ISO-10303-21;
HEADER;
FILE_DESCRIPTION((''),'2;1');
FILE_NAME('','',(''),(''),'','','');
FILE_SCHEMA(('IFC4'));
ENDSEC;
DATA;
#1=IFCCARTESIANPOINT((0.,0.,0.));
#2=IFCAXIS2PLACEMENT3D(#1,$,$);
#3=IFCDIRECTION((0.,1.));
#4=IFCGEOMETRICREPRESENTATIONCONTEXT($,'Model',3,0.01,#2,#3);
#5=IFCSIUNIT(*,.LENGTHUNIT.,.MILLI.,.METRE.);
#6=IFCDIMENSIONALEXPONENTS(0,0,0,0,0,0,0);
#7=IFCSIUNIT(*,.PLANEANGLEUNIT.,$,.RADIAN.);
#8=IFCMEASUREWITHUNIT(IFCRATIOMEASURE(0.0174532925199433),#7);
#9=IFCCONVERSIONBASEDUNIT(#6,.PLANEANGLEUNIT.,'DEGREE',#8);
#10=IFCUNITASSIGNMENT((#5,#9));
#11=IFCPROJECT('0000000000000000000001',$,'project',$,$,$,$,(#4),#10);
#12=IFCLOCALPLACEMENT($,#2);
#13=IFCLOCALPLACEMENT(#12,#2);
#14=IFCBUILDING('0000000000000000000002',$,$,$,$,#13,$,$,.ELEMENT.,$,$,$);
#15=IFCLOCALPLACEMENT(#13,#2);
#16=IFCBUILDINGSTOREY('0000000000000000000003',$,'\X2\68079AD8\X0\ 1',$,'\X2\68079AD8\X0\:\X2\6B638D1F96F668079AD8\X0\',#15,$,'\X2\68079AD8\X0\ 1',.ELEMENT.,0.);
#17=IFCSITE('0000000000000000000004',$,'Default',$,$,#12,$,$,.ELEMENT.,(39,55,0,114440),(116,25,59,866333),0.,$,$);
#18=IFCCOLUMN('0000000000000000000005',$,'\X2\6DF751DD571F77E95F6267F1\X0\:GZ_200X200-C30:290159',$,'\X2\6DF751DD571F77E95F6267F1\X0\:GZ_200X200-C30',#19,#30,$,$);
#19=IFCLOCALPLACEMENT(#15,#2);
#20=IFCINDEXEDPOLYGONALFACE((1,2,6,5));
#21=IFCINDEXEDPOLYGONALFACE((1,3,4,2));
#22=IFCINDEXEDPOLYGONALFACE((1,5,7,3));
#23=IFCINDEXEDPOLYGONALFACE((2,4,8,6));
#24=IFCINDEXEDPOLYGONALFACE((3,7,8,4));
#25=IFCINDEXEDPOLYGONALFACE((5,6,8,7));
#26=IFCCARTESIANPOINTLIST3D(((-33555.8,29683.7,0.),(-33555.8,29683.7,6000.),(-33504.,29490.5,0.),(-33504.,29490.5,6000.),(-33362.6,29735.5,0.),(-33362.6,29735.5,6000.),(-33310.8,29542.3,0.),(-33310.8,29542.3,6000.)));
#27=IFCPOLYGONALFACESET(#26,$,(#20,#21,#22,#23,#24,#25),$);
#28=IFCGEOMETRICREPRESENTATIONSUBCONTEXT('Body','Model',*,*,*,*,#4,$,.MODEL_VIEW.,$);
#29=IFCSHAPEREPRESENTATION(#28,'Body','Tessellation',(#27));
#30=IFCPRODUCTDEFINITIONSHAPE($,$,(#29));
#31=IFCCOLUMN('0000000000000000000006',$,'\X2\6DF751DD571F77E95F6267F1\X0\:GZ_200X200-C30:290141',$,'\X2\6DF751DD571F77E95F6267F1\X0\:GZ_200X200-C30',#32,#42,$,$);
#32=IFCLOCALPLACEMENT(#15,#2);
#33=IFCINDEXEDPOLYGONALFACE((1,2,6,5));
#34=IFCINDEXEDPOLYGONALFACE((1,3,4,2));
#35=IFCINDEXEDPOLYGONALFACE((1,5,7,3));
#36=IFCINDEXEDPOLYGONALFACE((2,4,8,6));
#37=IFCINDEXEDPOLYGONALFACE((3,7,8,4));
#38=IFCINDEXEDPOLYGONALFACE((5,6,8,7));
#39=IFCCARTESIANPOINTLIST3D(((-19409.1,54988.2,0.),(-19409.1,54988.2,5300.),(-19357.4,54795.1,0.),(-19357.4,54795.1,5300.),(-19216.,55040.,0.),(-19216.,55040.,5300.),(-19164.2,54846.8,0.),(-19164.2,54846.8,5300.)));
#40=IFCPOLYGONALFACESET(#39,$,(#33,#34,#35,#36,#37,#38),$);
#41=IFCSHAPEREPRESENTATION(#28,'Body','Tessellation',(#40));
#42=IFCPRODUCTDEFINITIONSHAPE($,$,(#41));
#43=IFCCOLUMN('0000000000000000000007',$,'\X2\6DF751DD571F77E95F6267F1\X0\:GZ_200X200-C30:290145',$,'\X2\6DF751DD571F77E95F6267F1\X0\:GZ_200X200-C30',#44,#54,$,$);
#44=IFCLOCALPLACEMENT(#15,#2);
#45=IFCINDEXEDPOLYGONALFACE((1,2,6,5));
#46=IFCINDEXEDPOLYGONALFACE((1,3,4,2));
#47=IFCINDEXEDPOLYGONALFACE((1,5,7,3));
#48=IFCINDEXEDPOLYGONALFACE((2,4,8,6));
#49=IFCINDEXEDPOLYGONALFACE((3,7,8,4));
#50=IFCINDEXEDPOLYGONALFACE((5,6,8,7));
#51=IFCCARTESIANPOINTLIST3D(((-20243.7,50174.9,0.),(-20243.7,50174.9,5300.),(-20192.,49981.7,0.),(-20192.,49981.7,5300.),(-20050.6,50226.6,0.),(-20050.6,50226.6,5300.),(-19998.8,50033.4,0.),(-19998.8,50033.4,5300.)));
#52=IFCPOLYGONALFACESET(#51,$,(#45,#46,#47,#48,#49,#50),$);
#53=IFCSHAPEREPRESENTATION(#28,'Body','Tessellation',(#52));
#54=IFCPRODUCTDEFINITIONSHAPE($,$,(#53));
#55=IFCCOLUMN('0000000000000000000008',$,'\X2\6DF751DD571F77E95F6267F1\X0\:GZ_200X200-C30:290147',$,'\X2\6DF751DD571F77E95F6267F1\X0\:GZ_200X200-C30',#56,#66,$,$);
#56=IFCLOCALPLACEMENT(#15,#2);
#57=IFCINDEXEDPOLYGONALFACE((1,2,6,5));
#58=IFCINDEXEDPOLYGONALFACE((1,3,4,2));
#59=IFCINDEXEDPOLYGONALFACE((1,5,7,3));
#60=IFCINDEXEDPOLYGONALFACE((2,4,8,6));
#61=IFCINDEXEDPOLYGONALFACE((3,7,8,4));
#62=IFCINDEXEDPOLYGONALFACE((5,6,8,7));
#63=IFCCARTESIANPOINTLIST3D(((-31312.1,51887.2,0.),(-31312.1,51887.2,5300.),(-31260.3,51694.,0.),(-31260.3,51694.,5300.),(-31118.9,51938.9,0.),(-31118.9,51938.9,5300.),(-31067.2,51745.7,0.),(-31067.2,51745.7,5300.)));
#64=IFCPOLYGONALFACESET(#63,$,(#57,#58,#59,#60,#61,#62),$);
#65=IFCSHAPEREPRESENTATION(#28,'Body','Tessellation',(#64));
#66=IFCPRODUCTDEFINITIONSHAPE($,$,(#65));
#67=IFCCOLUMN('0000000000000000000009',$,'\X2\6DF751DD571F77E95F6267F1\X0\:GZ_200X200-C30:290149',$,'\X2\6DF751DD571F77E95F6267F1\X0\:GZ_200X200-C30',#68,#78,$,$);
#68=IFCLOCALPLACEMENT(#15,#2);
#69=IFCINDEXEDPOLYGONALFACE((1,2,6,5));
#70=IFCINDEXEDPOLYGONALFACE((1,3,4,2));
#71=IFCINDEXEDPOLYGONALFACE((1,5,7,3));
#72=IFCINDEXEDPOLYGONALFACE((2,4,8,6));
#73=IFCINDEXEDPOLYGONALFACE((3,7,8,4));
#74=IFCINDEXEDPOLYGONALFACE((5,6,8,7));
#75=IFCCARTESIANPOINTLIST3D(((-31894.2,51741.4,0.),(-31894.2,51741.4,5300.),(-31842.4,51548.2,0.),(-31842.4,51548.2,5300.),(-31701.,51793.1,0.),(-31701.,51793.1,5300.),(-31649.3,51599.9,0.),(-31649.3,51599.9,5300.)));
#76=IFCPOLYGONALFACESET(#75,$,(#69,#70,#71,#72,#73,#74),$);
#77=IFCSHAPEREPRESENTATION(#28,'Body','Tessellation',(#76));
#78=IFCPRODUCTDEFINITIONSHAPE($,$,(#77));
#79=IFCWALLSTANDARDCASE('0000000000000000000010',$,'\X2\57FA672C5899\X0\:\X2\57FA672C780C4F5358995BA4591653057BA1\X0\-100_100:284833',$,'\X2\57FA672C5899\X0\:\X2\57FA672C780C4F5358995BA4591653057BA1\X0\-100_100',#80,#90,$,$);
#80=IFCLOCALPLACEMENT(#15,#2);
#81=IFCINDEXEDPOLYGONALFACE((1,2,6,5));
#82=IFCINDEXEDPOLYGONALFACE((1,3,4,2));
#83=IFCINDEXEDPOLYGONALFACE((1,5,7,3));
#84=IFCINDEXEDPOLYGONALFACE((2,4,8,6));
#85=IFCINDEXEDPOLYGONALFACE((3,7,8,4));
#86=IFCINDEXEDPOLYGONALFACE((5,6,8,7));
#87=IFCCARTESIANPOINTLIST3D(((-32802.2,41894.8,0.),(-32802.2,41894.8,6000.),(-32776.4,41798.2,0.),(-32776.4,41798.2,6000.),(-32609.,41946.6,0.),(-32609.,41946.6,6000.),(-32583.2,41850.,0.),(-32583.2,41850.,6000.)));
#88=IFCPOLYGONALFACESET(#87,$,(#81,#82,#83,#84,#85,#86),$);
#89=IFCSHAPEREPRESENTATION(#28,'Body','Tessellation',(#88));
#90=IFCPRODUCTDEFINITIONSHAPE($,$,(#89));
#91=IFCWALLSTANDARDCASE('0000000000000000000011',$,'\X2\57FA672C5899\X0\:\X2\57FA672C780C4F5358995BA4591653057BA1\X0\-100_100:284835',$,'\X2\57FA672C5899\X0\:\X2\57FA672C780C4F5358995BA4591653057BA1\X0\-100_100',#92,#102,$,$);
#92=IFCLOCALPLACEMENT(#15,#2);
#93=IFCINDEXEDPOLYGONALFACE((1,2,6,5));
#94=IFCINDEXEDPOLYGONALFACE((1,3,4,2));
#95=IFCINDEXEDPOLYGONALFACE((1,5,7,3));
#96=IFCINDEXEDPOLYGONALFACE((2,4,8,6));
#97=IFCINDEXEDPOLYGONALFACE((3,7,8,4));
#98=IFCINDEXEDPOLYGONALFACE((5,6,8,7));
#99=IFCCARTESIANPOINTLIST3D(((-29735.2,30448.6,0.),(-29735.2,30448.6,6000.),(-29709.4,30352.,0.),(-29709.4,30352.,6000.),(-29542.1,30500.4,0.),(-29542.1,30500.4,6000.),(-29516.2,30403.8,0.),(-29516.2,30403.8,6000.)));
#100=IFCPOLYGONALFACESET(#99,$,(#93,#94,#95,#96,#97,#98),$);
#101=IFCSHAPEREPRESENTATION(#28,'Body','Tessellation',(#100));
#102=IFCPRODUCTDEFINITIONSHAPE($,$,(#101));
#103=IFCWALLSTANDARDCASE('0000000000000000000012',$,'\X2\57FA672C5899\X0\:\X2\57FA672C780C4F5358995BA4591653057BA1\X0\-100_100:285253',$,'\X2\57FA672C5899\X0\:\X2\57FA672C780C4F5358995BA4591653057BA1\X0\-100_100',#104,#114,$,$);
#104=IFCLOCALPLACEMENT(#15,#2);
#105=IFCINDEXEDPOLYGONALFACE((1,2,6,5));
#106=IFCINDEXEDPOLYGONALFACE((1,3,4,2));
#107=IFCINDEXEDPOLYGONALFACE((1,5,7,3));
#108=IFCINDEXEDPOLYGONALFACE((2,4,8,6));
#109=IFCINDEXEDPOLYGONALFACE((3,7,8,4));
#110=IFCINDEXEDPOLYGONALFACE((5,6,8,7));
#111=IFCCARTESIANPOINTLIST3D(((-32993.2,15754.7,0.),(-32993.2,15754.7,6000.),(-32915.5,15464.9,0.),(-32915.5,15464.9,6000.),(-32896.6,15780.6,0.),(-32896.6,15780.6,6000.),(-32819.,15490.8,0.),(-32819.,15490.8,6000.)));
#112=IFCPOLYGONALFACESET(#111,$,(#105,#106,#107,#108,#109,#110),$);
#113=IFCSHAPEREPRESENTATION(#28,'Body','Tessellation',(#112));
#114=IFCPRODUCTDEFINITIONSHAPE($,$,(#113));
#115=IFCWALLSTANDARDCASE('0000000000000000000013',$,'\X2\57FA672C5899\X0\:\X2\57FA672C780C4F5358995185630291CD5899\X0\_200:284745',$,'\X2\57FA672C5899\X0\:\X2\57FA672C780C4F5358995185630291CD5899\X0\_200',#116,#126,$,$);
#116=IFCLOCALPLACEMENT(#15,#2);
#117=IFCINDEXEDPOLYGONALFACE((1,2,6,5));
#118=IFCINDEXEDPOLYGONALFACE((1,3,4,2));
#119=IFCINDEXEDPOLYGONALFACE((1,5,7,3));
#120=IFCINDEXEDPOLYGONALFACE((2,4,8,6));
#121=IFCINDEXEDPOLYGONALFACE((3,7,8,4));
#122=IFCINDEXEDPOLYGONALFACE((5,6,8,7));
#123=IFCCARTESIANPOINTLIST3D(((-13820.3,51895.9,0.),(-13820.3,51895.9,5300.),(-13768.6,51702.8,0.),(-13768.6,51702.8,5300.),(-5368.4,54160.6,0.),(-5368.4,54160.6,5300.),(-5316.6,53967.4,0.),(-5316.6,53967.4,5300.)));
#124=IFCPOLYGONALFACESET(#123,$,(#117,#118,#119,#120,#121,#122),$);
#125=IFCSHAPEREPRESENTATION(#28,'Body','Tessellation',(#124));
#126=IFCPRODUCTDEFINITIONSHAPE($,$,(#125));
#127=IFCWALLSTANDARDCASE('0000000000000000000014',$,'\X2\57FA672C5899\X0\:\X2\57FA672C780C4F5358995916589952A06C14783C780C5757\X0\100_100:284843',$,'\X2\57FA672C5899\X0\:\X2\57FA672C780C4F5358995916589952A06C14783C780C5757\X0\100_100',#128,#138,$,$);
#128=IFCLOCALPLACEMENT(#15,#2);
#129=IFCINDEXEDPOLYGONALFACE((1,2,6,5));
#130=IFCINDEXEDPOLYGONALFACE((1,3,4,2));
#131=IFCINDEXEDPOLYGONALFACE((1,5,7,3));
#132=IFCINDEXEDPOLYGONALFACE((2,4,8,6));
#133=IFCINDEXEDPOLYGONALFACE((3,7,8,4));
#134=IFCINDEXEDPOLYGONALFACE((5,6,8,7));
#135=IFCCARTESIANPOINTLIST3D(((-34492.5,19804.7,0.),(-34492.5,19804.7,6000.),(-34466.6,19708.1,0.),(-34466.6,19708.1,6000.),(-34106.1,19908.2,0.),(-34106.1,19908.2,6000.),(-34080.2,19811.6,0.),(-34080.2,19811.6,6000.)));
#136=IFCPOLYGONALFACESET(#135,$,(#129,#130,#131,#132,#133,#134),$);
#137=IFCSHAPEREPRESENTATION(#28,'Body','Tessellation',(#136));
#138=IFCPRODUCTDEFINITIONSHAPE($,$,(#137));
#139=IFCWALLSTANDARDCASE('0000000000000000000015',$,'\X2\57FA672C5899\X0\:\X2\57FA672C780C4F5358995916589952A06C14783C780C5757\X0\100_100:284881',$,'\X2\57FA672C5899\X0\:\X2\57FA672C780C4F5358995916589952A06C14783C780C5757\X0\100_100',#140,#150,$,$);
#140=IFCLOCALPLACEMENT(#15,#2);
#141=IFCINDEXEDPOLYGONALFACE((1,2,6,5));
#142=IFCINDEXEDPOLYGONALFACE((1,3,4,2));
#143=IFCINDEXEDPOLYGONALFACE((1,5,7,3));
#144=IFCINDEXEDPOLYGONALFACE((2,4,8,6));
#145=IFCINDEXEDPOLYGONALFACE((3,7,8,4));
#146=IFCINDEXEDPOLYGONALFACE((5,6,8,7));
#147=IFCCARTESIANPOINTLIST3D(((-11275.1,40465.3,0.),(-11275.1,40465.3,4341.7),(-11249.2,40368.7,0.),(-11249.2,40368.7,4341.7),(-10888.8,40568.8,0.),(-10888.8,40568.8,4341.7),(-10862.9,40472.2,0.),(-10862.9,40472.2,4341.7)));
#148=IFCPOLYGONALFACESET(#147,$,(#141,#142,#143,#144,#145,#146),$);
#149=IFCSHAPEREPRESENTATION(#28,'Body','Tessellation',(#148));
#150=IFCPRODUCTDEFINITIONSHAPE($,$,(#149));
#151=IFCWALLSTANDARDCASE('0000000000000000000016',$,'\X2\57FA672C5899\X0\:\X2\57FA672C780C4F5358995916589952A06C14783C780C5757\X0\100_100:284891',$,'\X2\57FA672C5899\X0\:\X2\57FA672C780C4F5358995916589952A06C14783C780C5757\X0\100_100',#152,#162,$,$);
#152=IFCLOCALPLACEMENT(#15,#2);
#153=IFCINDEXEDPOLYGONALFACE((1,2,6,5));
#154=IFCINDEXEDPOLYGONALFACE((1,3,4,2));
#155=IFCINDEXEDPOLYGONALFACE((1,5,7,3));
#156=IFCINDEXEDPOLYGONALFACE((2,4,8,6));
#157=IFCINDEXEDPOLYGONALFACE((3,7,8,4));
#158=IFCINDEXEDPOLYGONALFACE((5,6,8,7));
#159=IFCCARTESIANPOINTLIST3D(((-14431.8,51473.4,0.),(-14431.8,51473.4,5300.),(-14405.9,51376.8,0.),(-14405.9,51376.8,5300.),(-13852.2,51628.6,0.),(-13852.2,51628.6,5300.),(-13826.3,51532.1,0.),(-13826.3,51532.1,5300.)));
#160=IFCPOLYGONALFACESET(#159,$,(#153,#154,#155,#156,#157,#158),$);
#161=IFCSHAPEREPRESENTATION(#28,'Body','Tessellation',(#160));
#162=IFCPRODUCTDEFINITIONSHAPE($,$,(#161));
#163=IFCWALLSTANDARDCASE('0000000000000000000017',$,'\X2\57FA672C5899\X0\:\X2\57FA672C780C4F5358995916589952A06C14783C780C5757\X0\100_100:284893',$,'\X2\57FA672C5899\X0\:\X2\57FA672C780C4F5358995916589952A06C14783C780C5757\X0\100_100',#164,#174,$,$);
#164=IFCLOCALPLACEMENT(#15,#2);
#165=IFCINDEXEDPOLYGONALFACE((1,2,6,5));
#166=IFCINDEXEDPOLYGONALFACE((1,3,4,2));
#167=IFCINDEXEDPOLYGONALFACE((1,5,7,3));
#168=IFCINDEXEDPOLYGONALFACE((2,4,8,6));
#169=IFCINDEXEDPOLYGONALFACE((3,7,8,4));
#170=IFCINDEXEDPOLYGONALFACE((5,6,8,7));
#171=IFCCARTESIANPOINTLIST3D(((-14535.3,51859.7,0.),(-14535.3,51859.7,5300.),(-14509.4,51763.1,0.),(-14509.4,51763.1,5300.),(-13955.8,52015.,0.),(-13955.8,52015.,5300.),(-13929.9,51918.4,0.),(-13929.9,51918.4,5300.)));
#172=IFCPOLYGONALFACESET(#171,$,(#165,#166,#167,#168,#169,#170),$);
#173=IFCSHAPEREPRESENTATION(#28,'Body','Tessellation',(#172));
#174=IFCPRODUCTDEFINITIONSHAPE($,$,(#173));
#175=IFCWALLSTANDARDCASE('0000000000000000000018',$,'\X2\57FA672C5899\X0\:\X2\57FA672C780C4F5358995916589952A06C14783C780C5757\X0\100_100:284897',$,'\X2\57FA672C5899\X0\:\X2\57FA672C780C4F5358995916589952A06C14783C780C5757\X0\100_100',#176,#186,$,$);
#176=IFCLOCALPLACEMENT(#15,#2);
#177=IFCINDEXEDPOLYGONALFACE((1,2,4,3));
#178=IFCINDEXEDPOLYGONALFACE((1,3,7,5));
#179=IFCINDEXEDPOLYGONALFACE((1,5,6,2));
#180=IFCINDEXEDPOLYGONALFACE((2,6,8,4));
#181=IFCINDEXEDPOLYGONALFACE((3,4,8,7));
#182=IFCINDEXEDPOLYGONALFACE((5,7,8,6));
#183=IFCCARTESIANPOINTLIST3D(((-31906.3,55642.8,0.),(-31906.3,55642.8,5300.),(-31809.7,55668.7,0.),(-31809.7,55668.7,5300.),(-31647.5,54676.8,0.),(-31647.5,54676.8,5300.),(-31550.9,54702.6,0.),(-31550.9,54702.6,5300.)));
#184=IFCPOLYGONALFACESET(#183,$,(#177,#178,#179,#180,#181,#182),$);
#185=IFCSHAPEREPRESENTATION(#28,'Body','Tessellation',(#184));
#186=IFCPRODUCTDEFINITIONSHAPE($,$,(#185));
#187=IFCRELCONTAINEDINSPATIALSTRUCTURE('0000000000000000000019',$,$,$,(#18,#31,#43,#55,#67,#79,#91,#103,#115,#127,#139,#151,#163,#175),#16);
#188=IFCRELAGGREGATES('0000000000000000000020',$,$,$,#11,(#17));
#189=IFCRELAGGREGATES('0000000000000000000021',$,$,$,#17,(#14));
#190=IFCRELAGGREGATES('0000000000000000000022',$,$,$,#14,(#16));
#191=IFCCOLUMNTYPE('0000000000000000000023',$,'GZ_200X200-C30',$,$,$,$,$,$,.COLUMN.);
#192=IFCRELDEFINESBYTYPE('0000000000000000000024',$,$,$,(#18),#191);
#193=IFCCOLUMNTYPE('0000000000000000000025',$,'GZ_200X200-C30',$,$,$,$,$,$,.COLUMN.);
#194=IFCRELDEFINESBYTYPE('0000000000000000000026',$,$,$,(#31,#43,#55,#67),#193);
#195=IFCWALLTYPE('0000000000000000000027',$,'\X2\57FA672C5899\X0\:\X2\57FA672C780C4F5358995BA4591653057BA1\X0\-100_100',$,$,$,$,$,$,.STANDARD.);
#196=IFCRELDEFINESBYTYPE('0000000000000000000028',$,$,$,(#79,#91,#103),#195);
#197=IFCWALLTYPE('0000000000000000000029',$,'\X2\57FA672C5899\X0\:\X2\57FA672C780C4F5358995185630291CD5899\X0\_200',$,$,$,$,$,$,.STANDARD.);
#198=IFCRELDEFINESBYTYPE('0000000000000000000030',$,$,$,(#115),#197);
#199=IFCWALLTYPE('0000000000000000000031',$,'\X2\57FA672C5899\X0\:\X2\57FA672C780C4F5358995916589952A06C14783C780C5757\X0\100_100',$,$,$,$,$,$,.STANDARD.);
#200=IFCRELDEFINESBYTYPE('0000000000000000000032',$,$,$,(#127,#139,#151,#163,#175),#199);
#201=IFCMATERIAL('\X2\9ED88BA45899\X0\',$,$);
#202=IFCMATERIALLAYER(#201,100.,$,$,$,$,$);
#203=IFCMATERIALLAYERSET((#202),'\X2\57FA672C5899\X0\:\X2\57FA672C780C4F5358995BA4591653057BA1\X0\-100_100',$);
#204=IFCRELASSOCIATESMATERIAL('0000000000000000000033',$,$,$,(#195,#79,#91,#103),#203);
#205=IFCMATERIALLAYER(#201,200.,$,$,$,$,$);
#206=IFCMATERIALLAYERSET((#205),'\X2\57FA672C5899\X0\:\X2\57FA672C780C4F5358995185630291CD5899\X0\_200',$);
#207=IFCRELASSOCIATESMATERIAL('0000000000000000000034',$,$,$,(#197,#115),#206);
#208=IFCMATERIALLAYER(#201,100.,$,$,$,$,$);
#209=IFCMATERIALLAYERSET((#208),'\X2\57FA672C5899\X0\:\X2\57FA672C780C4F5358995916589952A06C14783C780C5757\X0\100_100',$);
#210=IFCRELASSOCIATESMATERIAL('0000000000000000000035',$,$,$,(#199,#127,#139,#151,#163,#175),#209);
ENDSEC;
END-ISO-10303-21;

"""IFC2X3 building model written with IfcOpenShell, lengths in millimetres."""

from ifc_helpers import new_model, entity, si_unit, converted_unit, direction, frame, frame_2d, origin, origin_2d_with_axis, place, context, subcontext, project, spatial, rectangle, extrude, source, transform, mapped, material, layer, layer_set, layer_usage, type_object, type_shapes, element, save


model = new_model("IFC2X3")

# Units and contexts
model_context = context("Model", 3, precision=0.01, world=origin(), true_north=direction((0.0, 1.0)))
body_context = subcontext(model_context, "Body", "Model", "MODEL_VIEW")
ifc_project = project(units=[si_unit("LENGTHUNIT", "METRE", prefix="MILLI"), converted_unit("PLANEANGLEUNIT", "DEGREE", entity("IfcRatioMeasure", 0.0174532925199433), si_unit("PLANEANGLEUNIT", "RADIAN"), dimensions=[0, 0, 0, 0, 0, 0, 0])], contexts=[model_context])

# Site, building, storey
site_placement = place(None, origin())
site = spatial("IfcSite", under=ifc_project, at=site_placement, Name="Default", CompositionType="ELEMENT", RefLatitude=(39, 55, 0, 114440), RefLongitude=(116, 25, 59, 866333), RefElevation=0.0)
building_placement = place(site_placement, origin())
building = spatial("IfcBuilding", under=site, at=building_placement, CompositionType="ELEMENT")
storey_placement = place(building_placement, origin())
storey = spatial("IfcBuildingStorey", under=building, at=storey_placement, Name="标高 1", ObjectType="标高:正负零标高", LongName="标高 1", CompositionType="ELEMENT", Elevation=0.0)

# Columns
column_type_1 = type_object("IfcColumnType", Name="GZ_200X200-C30", PredefinedType="COLUMN")
shared_shape_1 = source(origin(), body_context, "Body", "SweptSolid", [
    extrude(rectangle(XDim=200.0, YDim=200.0, at=origin_2d_with_axis()), frame((0.0, 0.0, 0.0), z_axis=(0.0, 0.0, 1.0), x_axis=(0.0, -1.0, 0.0)), (0.0, 0.0, 1.0), 6000.0),
])
type_shapes(column_type_1, [shared_shape_1])
for number, where, z_axis, x_axis, name in (
    (1, (-33433.3, 29613.0, 0.0), (0.0, 0.0, 1.0), (0.965926, 0.258819, 0.0), "混凝土矩形柱:GZ_200X200-C30:290159"),
):
    element("IfcColumn", number, at=place(building_placement, frame(where, z_axis=z_axis, x_axis=x_axis)), inside=storey, type_object=column_type_1, Name=name, ObjectType="混凝土矩形柱:GZ_200X200-C30", context=body_context, shape_type="MappedRepresentation", body=[
        mapped(shared_shape_1, transform((0.0, 0.0, 0.0), scale=1.0)),
    ])
column_type_2 = type_object("IfcColumnType", Name="GZ_200X200-C30", PredefinedType="COLUMN")
shared_shape_2 = source(origin(), body_context, "Body", "SweptSolid", [
    extrude(rectangle(XDim=200.0, YDim=200.0, at=origin_2d_with_axis()), frame((0.0, 0.0, 0.0), z_axis=(0.0, 0.0, 1.0), x_axis=(0.0, -1.0, 0.0)), (0.0, 0.0, 1.0), 5300.0),
])
type_shapes(column_type_2, [shared_shape_2])
for number, where, z_axis, x_axis, name in (
    (2, (-19286.7, 54917.5, 0.0), (0.0, 0.0, 1.0), (0.965926, 0.258819, 0.0), "混凝土矩形柱:GZ_200X200-C30:290141"),
    (3, (-20121.3, 50104.2, 0.0), (0.0, 0.0, 1.0), (0.965926, 0.258819, 0.0), "混凝土矩形柱:GZ_200X200-C30:290145"),
    (4, (-31189.6, 51816.4, 0.0), (0.0, 0.0, 1.0), (0.965926, 0.258819, 0.0), "混凝土矩形柱:GZ_200X200-C30:290147"),
    (5, (-31771.7, 51670.6, 0.0), (0.0, 0.0, 1.0), (0.965926, 0.258819, 0.0), "混凝土矩形柱:GZ_200X200-C30:290149"),
):
    element("IfcColumn", number, at=place(building_placement, frame(where, z_axis=z_axis, x_axis=x_axis)), inside=storey, type_object=column_type_2, Name=name, ObjectType="混凝土矩形柱:GZ_200X200-C30", context=body_context, shape_type="MappedRepresentation", body=[
        mapped(shared_shape_2, transform((0.0, 0.0, 0.0), scale=1.0)),
    ])

# Walls
ifc_material = material(Name="默认墙")
ifc_layer_1 = layer(ifc_material, 100.0)
ifc_layer_set_1 = layer_set([ifc_layer_1], Name="基本墙:基本砌体墙室外包管-100_100")
ifc_layer_usage_1 = layer_usage(ifc_layer_set_1, "AXIS2", "NEGATIVE", 50.0)
wall_type_1 = type_object("IfcWallType", Name="基本墙:基本砌体墙室外包管-100_100", PredefinedType="STANDARD", material=ifc_layer_set_1)
wall_1_placement = place(building_placement, frame((-32596.1, 41898.3, 0.0), z_axis=(0.0, 0.0, 1.0), x_axis=(-0.965926, -0.258819, 0.0)))
element("IfcWallStandardCase", 6, at=wall_1_placement, inside=storey, type_object=wall_type_1, material=ifc_layer_usage_1, Name="基本墙:基本砌体墙室外包管-100_100:284833", ObjectType="基本墙:基本砌体墙室外包管-100_100", context=body_context, shape_type="SweptSolid", body=[
    extrude(rectangle(XDim=200.0, YDim=100.0, at=frame_2d((100.0, 0.0), x_axis=(-1.0, 0.0))), origin(), (0.0, 0.0, 1.0), 6000.0),
])
ifc_layer_usage_2 = layer_usage(ifc_layer_set_1, "AXIS2", "NEGATIVE", 50.0)
wall_2_placement = place(building_placement, frame((-29529.1, 30452.1, 0.0), z_axis=(0.0, 0.0, 1.0), x_axis=(-0.965926, -0.258819, 0.0)))
element("IfcWallStandardCase", 7, at=wall_2_placement, inside=storey, type_object=wall_type_1, material=ifc_layer_usage_2, Name="基本墙:基本砌体墙室外包管-100_100:284835", ObjectType="基本墙:基本砌体墙室外包管-100_100", context=body_context, shape_type="SweptSolid", body=[
    extrude(rectangle(XDim=200.0, YDim=100.0, at=frame_2d((100.0, 0.0), x_axis=(-1.0, 0.0))), origin(), (0.0, 0.0, 1.0), 6000.0),
])
ifc_layer_usage_3 = layer_usage(ifc_layer_set_1, "AXIS2", "NEGATIVE", 50.0)
wall_3_placement = place(building_placement, frame((-32944.9, 15767.6, 0.0), z_axis=(0.0, 0.0, 1.0), x_axis=(0.258819, -0.965926, 0.0)))
element("IfcWallStandardCase", 8, at=wall_3_placement, inside=storey, type_object=wall_type_1, material=ifc_layer_usage_3, Name="基本墙:基本砌体墙室外包管-100_100:285253", ObjectType="基本墙:基本砌体墙室外包管-100_100", context=body_context, shape_type="SweptSolid", body=[
    extrude(rectangle(XDim=300.0, YDim=100.0, at=frame_2d((150.0, 0.0), x_axis=(-1.0, 0.0))), origin(), (0.0, 0.0, 1.0), 6000.0),
])
ifc_layer_2 = layer(ifc_material, 200.0)
ifc_layer_set_2 = layer_set([ifc_layer_2], Name="基本墙:基本砌体墙内挂重墙_200")
ifc_layer_usage_4 = layer_usage(ifc_layer_set_2, "AXIS2", "NEGATIVE", 100.0)
wall_type_2 = type_object("IfcWallType", Name="基本墙:基本砌体墙内挂重墙_200", PredefinedType="STANDARD", material=ifc_layer_set_2)
wall_4_placement = place(building_placement, frame((-13794.4, 51799.3, 0.0), z_axis=(0.0, 0.0, 1.0), x_axis=(0.965926, 0.258819, 0.0)))
element("IfcWallStandardCase", 9, at=wall_4_placement, inside=storey, type_object=wall_type_2, material=ifc_layer_usage_4, Name="基本墙:基本砌体墙内挂重墙_200:284745", ObjectType="基本墙:基本砌体墙内挂重墙_200", context=body_context, shape_type="SweptSolid", body=[
    extrude(rectangle(XDim=8750.1, YDim=200.0, at=frame_2d((4375.0, 0.0), x_axis=(-1.0, 0.0))), origin(), (0.0, 0.0, 1.0), 5300.0),
])
ifc_layer_3 = layer(ifc_material, 100.0)
ifc_layer_set_3 = layer_set([ifc_layer_3], Name="基本墙:基本砌体墙外墙加气砼砌块100_100")
ifc_layer_usage_5 = layer_usage(ifc_layer_set_3, "AXIS2", "NEGATIVE", 50.0)
wall_type_3 = type_object("IfcWallType", Name="基本墙:基本砌体墙外墙加气砼砌块100_100", PredefinedType="STANDARD", material=ifc_layer_set_3)
wall_5_placement = place(building_placement, frame((-34479.5, 19756.4, 0.0), z_axis=(0.0, 0.0, 1.0), x_axis=(0.965926, 0.258819, 0.0)))
element("IfcWallStandardCase", 10, at=wall_5_placement, inside=storey, type_object=wall_type_3, material=ifc_layer_usage_5, Name="基本墙:基本砌体墙外墙加气砼砌块100_100:284843", ObjectType="基本墙:基本砌体墙外墙加气砼砌块100_100", context=body_context, shape_type="SweptSolid", body=[
    extrude(rectangle(XDim=400.0, YDim=100.0, at=frame_2d((200.0, 0.0), x_axis=(-1.0, 0.0))), origin(), (0.0, 0.0, 1.0), 6000.0),
])
ifc_layer_usage_6 = layer_usage(ifc_layer_set_3, "AXIS2", "NEGATIVE", 50.0)
wall_6_placement = place(building_placement, frame((-11262.2, 40417.0, 0.0), z_axis=(0.0, 0.0, 1.0), x_axis=(0.965926, 0.258819, 0.0)))
element("IfcWallStandardCase", 11, at=wall_6_placement, inside=storey, type_object=wall_type_3, material=ifc_layer_usage_6, Name="基本墙:基本砌体墙外墙加气砼砌块100_100:284881", ObjectType="基本墙:基本砌体墙外墙加气砼砌块100_100", context=body_context, shape_type="SweptSolid", body=[
    extrude(rectangle(XDim=400.0, YDim=100.0, at=frame_2d((200.0, 0.0), x_axis=(-1.0, 0.0))), origin(), (0.0, 0.0, 1.0), 4341.7),
])
ifc_layer_usage_7 = layer_usage(ifc_layer_set_3, "AXIS2", "NEGATIVE", 50.0)
wall_7_placement = place(building_placement, frame((-14418.8, 51425.1, 0.0), z_axis=(0.0, 0.0, 1.0), x_axis=(0.965926, 0.258819, 0.0)))
element("IfcWallStandardCase", 12, at=wall_7_placement, inside=storey, type_object=wall_type_3, material=ifc_layer_usage_7, Name="基本墙:基本砌体墙外墙加气砼砌块100_100:284891", ObjectType="基本墙:基本砌体墙外墙加气砼砌块100_100", context=body_context, shape_type="SweptSolid", body=[
    extrude(rectangle(XDim=600.0, YDim=100.0, at=frame_2d((300.0, 0.0), x_axis=(-1.0, 0.0))), origin(), (0.0, 0.0, 1.0), 5300.0),
])
ifc_layer_usage_8 = layer_usage(ifc_layer_set_3, "AXIS2", "NEGATIVE", 50.0)
wall_8_placement = place(building_placement, frame((-14522.4, 51811.4, 0.0), z_axis=(0.0, 0.0, 1.0), x_axis=(0.965926, 0.258819, 0.0)))
element("IfcWallStandardCase", 13, at=wall_8_placement, inside=storey, type_object=wall_type_3, material=ifc_layer_usage_8, Name="基本墙:基本砌体墙外墙加气砼砌块100_100:284893", ObjectType="基本墙:基本砌体墙外墙加气砼砌块100_100", context=body_context, shape_type="SweptSolid", body=[
    extrude(rectangle(XDim=600.0, YDim=100.0, at=frame_2d((300.0, 0.0), x_axis=(-1.0, 0.0))), origin(), (0.0, 0.0, 1.0), 5300.0),
])
ifc_layer_usage_9 = layer_usage(ifc_layer_set_3, "AXIS2", "NEGATIVE", 50.0)
wall_9_placement = place(building_placement, frame((-31599.2, 54689.7, 0.0), z_axis=(0.0, 0.0, 1.0), x_axis=(-0.258819, 0.965926, 0.0)))
element("IfcWallStandardCase", 14, at=wall_9_placement, inside=storey, type_object=wall_type_3, material=ifc_layer_usage_9, Name="基本墙:基本砌体墙外墙加气砼砌块100_100:284897", ObjectType="基本墙:基本砌体墙外墙加气砼砌块100_100", context=body_context, shape_type="SweptSolid", body=[
    extrude(rectangle(XDim=1000.1, YDim=100.0, at=frame_2d((500.0, 0.0), x_axis=(-1.0, 0.0))), origin(), (0.0, 0.0, 1.0), 5300.0),
])

save(model, "model.ifc")
